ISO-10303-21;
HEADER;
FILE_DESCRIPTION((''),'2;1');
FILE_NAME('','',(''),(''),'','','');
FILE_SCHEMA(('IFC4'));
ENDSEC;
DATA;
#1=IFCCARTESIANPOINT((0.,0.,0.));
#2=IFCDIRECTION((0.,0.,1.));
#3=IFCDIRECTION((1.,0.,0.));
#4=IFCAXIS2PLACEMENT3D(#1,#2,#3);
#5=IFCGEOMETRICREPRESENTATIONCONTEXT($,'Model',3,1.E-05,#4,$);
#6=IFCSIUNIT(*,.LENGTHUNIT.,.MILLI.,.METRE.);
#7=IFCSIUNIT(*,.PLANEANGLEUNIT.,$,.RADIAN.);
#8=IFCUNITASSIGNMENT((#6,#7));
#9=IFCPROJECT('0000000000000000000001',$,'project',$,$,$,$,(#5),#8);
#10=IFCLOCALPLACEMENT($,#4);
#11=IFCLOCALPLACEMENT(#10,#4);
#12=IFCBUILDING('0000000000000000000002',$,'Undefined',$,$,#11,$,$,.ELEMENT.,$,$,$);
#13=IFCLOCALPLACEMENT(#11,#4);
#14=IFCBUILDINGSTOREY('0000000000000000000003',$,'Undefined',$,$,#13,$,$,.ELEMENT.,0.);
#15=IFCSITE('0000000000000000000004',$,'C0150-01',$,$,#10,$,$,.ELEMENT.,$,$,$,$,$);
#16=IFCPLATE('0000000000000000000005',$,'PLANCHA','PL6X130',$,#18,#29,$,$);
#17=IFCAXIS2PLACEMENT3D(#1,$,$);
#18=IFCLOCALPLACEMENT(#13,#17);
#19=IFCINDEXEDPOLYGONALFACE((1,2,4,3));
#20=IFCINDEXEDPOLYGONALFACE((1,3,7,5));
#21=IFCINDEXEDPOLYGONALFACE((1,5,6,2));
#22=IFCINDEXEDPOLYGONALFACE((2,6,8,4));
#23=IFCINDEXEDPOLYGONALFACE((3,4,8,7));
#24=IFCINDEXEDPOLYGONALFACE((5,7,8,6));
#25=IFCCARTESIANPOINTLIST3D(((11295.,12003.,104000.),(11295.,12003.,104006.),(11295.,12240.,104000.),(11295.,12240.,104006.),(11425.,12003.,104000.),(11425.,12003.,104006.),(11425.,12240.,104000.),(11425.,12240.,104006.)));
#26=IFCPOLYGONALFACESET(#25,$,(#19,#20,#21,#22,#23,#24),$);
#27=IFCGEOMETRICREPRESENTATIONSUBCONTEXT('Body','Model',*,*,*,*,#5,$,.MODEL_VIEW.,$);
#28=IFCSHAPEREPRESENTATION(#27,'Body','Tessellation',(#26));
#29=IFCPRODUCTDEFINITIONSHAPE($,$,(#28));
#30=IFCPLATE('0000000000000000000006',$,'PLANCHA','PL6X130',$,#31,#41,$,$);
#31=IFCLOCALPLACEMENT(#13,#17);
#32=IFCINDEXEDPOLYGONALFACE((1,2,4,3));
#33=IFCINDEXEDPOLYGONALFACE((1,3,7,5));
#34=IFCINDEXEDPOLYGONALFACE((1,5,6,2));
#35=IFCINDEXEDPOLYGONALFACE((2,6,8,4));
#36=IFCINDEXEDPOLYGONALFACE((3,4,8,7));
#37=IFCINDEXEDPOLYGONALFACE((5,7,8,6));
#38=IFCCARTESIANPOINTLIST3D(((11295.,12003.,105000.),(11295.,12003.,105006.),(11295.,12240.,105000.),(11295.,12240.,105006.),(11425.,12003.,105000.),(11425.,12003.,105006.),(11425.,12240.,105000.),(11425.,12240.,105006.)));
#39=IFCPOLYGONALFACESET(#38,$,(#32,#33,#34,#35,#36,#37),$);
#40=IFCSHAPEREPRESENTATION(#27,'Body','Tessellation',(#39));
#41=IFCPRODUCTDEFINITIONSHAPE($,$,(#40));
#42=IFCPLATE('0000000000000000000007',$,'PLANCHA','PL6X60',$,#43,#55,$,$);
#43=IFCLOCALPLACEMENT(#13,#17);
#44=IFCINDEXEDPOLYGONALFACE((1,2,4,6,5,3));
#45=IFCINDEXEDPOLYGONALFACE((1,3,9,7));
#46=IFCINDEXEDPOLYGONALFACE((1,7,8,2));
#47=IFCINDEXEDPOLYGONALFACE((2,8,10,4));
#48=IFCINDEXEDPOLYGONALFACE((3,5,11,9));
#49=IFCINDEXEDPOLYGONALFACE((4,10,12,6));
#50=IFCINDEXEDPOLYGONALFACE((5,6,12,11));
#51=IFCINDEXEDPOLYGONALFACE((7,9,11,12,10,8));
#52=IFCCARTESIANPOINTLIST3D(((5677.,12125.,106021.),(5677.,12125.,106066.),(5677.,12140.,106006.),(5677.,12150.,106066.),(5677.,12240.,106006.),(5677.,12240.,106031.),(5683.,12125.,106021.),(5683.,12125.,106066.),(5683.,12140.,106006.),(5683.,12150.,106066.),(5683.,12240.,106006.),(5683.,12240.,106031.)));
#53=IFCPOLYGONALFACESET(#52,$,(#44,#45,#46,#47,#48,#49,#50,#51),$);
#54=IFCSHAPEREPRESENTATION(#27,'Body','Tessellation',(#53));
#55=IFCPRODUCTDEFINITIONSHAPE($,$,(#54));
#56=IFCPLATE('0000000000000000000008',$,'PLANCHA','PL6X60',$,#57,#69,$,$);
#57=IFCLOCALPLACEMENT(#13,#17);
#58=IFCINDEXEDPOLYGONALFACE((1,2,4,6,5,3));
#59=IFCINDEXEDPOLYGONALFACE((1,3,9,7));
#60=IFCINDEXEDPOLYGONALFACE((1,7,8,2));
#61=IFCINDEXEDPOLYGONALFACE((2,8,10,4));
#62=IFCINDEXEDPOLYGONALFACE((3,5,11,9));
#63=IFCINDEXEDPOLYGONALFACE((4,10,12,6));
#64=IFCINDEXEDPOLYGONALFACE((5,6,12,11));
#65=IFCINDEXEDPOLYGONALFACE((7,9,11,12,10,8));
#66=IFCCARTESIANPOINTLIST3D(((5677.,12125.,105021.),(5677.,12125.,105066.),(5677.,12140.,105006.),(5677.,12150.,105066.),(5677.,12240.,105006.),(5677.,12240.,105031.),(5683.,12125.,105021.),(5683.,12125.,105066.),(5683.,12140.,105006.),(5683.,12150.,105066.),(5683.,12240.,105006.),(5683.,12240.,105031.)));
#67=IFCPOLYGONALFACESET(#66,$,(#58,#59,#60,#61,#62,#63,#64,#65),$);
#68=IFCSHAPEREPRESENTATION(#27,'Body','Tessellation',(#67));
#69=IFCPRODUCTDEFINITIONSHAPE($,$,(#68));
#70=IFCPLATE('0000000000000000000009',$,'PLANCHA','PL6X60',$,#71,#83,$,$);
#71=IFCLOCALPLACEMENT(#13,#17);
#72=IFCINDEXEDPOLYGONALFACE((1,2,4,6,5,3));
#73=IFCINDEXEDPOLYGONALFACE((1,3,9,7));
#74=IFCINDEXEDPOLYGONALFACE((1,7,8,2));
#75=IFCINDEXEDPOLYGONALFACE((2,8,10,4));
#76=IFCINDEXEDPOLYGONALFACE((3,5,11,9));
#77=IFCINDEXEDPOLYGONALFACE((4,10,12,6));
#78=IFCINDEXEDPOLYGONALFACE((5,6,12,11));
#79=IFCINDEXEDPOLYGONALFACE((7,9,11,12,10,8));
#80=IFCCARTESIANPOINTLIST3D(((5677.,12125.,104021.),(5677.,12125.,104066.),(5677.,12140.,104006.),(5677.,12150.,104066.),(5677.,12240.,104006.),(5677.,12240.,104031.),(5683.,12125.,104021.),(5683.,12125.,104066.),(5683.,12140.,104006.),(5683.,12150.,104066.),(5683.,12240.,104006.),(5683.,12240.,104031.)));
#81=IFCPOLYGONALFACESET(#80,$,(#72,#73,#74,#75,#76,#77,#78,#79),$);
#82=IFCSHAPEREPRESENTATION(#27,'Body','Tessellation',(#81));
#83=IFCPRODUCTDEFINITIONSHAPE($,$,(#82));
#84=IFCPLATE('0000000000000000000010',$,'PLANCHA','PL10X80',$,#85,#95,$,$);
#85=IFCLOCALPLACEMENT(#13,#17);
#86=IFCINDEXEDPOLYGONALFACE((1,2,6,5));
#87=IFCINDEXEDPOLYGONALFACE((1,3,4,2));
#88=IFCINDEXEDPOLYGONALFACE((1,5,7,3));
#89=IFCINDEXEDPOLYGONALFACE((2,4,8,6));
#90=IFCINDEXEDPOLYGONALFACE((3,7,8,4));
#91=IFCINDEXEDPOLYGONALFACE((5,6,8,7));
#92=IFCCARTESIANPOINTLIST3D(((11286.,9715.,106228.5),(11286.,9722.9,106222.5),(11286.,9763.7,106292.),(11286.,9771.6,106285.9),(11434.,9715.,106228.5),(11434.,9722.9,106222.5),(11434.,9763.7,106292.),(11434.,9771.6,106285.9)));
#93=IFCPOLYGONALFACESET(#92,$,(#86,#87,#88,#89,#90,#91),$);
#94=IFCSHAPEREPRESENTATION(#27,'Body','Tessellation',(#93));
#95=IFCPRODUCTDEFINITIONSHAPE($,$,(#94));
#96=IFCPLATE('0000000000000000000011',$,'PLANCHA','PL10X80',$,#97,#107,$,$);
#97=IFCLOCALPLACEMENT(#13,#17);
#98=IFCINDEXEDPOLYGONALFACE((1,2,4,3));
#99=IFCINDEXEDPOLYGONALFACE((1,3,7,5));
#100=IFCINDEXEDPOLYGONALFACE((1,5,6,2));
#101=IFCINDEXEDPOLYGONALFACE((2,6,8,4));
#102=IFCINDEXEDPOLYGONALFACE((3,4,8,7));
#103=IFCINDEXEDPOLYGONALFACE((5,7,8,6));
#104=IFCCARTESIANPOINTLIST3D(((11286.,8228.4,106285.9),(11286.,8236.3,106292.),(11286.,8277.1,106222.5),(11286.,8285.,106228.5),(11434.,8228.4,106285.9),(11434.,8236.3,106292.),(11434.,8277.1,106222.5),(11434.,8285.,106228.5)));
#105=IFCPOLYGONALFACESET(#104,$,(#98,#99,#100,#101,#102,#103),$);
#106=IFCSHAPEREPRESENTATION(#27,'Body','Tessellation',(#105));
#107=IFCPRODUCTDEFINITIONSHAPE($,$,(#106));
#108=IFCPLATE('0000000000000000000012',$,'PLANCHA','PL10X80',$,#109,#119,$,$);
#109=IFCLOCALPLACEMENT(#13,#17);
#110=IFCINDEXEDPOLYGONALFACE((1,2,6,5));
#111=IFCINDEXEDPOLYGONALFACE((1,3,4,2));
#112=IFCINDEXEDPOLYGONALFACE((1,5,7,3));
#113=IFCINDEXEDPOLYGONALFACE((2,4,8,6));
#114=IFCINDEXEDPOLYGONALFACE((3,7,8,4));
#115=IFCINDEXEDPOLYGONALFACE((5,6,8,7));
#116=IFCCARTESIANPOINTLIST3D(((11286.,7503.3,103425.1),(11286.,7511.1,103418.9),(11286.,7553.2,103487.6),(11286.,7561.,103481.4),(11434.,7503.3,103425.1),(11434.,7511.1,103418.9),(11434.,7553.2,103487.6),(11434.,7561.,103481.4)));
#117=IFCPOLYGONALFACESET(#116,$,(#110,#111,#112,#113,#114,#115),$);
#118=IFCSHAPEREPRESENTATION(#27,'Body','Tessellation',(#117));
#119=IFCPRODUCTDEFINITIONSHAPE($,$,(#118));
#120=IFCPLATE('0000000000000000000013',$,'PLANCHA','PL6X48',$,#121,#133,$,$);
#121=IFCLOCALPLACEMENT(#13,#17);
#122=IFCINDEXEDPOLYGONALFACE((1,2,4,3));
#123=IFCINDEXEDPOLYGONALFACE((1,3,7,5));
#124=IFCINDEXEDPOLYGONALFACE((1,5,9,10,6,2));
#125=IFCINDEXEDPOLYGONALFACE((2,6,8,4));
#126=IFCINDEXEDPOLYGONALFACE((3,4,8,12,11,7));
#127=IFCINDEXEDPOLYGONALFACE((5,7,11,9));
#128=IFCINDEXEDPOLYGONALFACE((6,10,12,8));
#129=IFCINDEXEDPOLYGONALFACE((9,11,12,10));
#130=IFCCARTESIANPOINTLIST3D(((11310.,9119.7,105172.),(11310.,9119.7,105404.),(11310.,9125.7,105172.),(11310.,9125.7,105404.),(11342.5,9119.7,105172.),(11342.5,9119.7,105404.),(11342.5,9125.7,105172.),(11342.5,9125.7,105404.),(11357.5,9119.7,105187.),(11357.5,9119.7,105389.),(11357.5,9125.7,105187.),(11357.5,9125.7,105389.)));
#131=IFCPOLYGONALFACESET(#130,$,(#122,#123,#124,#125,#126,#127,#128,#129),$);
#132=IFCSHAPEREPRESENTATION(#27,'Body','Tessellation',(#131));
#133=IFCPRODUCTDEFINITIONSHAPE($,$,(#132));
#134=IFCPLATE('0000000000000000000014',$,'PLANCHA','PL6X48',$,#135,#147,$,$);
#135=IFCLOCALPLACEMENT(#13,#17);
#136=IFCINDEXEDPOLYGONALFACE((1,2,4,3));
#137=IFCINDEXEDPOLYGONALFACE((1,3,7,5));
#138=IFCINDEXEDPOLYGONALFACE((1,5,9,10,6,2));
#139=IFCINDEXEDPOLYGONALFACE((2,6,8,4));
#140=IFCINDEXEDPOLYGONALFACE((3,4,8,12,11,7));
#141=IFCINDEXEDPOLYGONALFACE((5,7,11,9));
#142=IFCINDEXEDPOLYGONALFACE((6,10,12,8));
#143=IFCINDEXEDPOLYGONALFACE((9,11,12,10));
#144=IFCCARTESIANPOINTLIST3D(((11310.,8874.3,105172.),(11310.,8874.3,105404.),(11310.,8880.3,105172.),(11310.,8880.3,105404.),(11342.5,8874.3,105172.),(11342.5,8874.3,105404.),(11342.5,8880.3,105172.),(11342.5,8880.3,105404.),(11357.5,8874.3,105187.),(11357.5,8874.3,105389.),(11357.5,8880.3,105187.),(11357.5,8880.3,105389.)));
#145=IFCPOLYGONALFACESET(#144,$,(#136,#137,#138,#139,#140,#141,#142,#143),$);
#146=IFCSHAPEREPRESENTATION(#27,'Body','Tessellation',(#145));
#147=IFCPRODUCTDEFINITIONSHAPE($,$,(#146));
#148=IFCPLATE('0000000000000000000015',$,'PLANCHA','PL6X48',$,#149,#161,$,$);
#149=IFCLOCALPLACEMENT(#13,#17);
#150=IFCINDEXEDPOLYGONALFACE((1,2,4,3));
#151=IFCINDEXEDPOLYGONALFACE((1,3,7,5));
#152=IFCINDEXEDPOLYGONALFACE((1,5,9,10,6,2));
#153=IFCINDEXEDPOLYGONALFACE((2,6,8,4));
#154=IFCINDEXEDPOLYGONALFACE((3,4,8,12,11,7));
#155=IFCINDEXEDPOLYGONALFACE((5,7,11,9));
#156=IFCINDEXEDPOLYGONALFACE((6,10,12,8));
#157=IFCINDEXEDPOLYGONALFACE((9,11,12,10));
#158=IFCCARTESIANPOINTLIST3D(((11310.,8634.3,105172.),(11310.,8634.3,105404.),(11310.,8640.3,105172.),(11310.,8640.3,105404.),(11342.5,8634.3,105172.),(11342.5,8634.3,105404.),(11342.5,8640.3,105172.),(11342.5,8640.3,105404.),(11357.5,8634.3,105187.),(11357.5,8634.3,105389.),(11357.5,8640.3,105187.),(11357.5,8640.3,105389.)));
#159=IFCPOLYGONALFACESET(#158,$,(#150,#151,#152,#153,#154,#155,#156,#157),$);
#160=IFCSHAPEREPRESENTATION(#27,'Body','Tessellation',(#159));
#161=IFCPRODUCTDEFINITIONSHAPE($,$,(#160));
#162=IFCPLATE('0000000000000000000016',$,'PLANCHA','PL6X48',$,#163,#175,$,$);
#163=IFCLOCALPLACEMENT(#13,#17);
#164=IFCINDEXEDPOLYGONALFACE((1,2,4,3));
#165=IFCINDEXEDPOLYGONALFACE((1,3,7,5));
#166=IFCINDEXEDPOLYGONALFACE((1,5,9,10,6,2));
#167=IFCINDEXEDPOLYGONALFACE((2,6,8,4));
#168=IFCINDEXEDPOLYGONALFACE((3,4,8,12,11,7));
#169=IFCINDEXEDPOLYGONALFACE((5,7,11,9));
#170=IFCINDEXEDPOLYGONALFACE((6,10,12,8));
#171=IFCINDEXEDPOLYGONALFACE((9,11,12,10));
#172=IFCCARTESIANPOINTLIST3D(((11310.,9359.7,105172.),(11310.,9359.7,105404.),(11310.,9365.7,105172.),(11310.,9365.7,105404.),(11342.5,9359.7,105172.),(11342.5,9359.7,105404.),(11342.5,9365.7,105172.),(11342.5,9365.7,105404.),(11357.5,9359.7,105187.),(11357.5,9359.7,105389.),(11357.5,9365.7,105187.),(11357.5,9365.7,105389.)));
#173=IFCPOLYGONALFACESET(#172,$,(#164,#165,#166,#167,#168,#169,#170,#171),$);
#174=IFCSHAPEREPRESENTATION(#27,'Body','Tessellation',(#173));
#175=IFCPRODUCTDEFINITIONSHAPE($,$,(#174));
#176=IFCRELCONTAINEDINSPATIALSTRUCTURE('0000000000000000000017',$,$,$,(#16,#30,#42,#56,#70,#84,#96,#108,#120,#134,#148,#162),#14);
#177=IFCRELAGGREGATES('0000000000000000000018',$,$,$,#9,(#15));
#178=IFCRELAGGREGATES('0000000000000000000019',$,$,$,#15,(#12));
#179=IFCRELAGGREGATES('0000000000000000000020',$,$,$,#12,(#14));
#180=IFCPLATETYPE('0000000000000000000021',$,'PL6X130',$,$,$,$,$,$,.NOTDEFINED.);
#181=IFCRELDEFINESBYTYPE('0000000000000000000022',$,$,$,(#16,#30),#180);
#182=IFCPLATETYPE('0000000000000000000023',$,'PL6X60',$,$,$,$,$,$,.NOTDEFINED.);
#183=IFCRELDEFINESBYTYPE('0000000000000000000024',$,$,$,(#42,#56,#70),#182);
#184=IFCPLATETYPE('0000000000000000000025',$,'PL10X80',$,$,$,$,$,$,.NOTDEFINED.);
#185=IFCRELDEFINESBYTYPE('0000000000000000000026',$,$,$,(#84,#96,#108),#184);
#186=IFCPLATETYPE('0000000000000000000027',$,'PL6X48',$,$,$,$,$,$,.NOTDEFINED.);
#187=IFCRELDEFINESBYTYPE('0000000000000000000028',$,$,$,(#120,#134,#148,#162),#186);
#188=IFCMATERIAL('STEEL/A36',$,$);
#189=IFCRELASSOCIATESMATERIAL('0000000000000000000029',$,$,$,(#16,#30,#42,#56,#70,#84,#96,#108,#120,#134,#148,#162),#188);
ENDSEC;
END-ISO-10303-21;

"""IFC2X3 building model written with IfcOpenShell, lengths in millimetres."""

from ifc_helpers import new_model, si_unit, frame, origin_with_axes, place, context, subcontext, project, spatial, polyline, outline, extrude, material, type_object, element, save


model = new_model("IFC2X3")

# Units and contexts
model_context = context("Model", 3, precision=1e-05, world=origin_with_axes())
body_context = subcontext(model_context, "Body", "Model", "MODEL_VIEW")
ifc_project = project(units=[si_unit("LENGTHUNIT", "METRE", prefix="MILLI"), si_unit("PLANEANGLEUNIT", "RADIAN")], contexts=[model_context])

# Site, building, storey
site_placement = place(None, origin_with_axes())
site = spatial("IfcSite", under=ifc_project, at=site_placement, Name="C0150-01", CompositionType="ELEMENT")
building_placement = place(site_placement, origin_with_axes())
building = spatial("IfcBuilding", under=site, at=building_placement, Name="Undefined", CompositionType="ELEMENT")
storey_placement = place(building_placement, origin_with_axes())
storey = spatial("IfcBuildingStorey", under=building, at=storey_placement, Name="Undefined", CompositionType="ELEMENT", Elevation=0.0)

# Shared definitions
ifc_material_1 = material(Name="STEEL/A36")

# Plates
plate_type_1 = type_object("IfcPlateType", Name="PL6X130", PredefinedType="NOTDEFINED")
for number, where, z_axis, x_axis, name in (
    (1, (11295.0, 12003.0, 104003.0), (0.0, -0.000002, 1.0), (1.0, 0.0, 0.0), "PLANCHA"),
    (2, (11295.0, 12003.0, 105003.0), (0.0, -0.000002, 1.0), (1.0, 0.0, 0.0), "PLANCHA"),
):
    element("IfcPlate", number, at=place(storey_placement, frame(where, z_axis=z_axis, x_axis=x_axis)), inside=storey, type_object=plate_type_1, material=ifc_material_1, Name=name, Description="PL6X130", context=body_context, shape_type="SweptSolid", body=[
        extrude(outline(polyline([(0.0, 0.0), (130.0, 0.0), (130.0, 237.0), (0.0, 237.0), (0.0, 0.0)])), frame((0.0, 0.0, -3.0), z_axis=(0.0, 0.0, 1.0), x_axis=(1.0, 0.0, 0.0)), (0.0, 0.0, 1.0), 6.0),
    ])
plate_type_2 = type_object("IfcPlateType", Name="PL6X60", PredefinedType="NOTDEFINED")
for number, where, z_axis, x_axis, name in (
    (3, (5680.0, 12240.0, 106031.0), (-1.0, 0.0, 0.0), (0.0, 0.000004, -1.0), "PLANCHA"),
    (4, (5680.0, 12240.0, 105031.0), (-1.0, 0.0, 0.0), (0.0, 0.000004, -1.0), "PLANCHA"),
    (5, (5680.0, 12240.0, 104031.0), (-1.0, 0.0, 0.0), (0.0, 0.000004, -1.0), "PLANCHA"),
):
    element("IfcPlate", number, at=place(storey_placement, frame(where, z_axis=z_axis, x_axis=x_axis)), inside=storey, type_object=plate_type_2, material=ifc_material_1, Name=name, Description="PL6X60", context=body_context, shape_type="SweptSolid", body=[
        extrude(outline(polyline([(0.0, 0.0), (25.0, 0.0), (25.0, 100.0), (10.0, 115.0), (-35.0, 115.0), (-35.0, 90.0), (0.0, 0.0)])), frame((0.0, 0.0, -3.0), z_axis=(0.0, 0.0, 1.0), x_axis=(1.0, 0.0, 0.0)), (0.0, 0.0, 1.0), 6.0),
    ])
plate_type_3 = type_object("IfcPlateType", Name="PL10X80", PredefinedType="NOTDEFINED")
for number, where, z_axis, x_axis, name in (
    (6, (11286.0, 9718.9, 106225.5), (0.0, 0.793528, -0.608534), (0.0, 0.608534, 0.793528), "PLANCHA"),
    (7, (11286.0, 8281.1, 106225.5), (0.0, 0.793528, 0.608534), (0.0, -0.608534, 0.793528), "PLANCHA"),
    (8, (11286.0, 7557.1, 103484.5), (0.0, -0.781922, 0.623376), (0.0, -0.623376, -0.781922), "PLANCHA"),
):
    element("IfcPlate", number, at=place(storey_placement, frame(where, z_axis=z_axis, x_axis=x_axis)), inside=storey, type_object=plate_type_3, material=ifc_material_1, Name=name, Description="PL10X80", context=body_context, shape_type="SweptSolid", body=[
        extrude(outline(polyline([(0.0, 0.0), (80.0, 0.0), (80.0, 148.0), (0.0, 148.0), (0.0, 0.0)])), frame((0.0, 0.0, -5.0), z_axis=(0.0, 0.0, 1.0), x_axis=(1.0, 0.0, 0.0)), (0.0, 0.0, 1.0), 10.0),
    ])
plate_type_4 = type_object("IfcPlateType", Name="PL6X48", PredefinedType="NOTDEFINED")
for number, where, z_axis, x_axis, name in (
    (9, (11310.0, 9122.7, 105404.0), (0.0, 1.0, 0.0), (1.0, 0.0, 0.0), "PLANCHA"),
    (10, (11310.0, 8877.3, 105404.0), (0.0, 1.0, 0.0), (1.0, 0.0, 0.0), "PLANCHA"),
    (11, (11310.0, 8637.3, 105404.0), (0.0, 1.0, 0.0), (1.0, 0.0, 0.0), "PLANCHA"),
    (12, (11310.0, 9362.7, 105404.0), (0.0, 1.0, 0.0), (1.0, 0.0, 0.0), "PLANCHA"),
):
    element("IfcPlate", number, at=place(storey_placement, frame(where, z_axis=z_axis, x_axis=x_axis)), inside=storey, type_object=plate_type_4, material=ifc_material_1, Name=name, Description="PL6X48", context=body_context, shape_type="SweptSolid", body=[
        extrude(outline(polyline([(0.0, 0.0), (32.5, 0.0), (47.5, 15.0), (47.5, 217.0), (32.5, 232.0), (0.0, 232.0), (0.0, 0.0)])), frame((0.0, 0.0, -3.0), z_axis=(0.0, 0.0, 1.0), x_axis=(1.0, 0.0, 0.0)), (0.0, 0.0, 1.0), 6.0),
    ])

save(model, "model.ifc")
